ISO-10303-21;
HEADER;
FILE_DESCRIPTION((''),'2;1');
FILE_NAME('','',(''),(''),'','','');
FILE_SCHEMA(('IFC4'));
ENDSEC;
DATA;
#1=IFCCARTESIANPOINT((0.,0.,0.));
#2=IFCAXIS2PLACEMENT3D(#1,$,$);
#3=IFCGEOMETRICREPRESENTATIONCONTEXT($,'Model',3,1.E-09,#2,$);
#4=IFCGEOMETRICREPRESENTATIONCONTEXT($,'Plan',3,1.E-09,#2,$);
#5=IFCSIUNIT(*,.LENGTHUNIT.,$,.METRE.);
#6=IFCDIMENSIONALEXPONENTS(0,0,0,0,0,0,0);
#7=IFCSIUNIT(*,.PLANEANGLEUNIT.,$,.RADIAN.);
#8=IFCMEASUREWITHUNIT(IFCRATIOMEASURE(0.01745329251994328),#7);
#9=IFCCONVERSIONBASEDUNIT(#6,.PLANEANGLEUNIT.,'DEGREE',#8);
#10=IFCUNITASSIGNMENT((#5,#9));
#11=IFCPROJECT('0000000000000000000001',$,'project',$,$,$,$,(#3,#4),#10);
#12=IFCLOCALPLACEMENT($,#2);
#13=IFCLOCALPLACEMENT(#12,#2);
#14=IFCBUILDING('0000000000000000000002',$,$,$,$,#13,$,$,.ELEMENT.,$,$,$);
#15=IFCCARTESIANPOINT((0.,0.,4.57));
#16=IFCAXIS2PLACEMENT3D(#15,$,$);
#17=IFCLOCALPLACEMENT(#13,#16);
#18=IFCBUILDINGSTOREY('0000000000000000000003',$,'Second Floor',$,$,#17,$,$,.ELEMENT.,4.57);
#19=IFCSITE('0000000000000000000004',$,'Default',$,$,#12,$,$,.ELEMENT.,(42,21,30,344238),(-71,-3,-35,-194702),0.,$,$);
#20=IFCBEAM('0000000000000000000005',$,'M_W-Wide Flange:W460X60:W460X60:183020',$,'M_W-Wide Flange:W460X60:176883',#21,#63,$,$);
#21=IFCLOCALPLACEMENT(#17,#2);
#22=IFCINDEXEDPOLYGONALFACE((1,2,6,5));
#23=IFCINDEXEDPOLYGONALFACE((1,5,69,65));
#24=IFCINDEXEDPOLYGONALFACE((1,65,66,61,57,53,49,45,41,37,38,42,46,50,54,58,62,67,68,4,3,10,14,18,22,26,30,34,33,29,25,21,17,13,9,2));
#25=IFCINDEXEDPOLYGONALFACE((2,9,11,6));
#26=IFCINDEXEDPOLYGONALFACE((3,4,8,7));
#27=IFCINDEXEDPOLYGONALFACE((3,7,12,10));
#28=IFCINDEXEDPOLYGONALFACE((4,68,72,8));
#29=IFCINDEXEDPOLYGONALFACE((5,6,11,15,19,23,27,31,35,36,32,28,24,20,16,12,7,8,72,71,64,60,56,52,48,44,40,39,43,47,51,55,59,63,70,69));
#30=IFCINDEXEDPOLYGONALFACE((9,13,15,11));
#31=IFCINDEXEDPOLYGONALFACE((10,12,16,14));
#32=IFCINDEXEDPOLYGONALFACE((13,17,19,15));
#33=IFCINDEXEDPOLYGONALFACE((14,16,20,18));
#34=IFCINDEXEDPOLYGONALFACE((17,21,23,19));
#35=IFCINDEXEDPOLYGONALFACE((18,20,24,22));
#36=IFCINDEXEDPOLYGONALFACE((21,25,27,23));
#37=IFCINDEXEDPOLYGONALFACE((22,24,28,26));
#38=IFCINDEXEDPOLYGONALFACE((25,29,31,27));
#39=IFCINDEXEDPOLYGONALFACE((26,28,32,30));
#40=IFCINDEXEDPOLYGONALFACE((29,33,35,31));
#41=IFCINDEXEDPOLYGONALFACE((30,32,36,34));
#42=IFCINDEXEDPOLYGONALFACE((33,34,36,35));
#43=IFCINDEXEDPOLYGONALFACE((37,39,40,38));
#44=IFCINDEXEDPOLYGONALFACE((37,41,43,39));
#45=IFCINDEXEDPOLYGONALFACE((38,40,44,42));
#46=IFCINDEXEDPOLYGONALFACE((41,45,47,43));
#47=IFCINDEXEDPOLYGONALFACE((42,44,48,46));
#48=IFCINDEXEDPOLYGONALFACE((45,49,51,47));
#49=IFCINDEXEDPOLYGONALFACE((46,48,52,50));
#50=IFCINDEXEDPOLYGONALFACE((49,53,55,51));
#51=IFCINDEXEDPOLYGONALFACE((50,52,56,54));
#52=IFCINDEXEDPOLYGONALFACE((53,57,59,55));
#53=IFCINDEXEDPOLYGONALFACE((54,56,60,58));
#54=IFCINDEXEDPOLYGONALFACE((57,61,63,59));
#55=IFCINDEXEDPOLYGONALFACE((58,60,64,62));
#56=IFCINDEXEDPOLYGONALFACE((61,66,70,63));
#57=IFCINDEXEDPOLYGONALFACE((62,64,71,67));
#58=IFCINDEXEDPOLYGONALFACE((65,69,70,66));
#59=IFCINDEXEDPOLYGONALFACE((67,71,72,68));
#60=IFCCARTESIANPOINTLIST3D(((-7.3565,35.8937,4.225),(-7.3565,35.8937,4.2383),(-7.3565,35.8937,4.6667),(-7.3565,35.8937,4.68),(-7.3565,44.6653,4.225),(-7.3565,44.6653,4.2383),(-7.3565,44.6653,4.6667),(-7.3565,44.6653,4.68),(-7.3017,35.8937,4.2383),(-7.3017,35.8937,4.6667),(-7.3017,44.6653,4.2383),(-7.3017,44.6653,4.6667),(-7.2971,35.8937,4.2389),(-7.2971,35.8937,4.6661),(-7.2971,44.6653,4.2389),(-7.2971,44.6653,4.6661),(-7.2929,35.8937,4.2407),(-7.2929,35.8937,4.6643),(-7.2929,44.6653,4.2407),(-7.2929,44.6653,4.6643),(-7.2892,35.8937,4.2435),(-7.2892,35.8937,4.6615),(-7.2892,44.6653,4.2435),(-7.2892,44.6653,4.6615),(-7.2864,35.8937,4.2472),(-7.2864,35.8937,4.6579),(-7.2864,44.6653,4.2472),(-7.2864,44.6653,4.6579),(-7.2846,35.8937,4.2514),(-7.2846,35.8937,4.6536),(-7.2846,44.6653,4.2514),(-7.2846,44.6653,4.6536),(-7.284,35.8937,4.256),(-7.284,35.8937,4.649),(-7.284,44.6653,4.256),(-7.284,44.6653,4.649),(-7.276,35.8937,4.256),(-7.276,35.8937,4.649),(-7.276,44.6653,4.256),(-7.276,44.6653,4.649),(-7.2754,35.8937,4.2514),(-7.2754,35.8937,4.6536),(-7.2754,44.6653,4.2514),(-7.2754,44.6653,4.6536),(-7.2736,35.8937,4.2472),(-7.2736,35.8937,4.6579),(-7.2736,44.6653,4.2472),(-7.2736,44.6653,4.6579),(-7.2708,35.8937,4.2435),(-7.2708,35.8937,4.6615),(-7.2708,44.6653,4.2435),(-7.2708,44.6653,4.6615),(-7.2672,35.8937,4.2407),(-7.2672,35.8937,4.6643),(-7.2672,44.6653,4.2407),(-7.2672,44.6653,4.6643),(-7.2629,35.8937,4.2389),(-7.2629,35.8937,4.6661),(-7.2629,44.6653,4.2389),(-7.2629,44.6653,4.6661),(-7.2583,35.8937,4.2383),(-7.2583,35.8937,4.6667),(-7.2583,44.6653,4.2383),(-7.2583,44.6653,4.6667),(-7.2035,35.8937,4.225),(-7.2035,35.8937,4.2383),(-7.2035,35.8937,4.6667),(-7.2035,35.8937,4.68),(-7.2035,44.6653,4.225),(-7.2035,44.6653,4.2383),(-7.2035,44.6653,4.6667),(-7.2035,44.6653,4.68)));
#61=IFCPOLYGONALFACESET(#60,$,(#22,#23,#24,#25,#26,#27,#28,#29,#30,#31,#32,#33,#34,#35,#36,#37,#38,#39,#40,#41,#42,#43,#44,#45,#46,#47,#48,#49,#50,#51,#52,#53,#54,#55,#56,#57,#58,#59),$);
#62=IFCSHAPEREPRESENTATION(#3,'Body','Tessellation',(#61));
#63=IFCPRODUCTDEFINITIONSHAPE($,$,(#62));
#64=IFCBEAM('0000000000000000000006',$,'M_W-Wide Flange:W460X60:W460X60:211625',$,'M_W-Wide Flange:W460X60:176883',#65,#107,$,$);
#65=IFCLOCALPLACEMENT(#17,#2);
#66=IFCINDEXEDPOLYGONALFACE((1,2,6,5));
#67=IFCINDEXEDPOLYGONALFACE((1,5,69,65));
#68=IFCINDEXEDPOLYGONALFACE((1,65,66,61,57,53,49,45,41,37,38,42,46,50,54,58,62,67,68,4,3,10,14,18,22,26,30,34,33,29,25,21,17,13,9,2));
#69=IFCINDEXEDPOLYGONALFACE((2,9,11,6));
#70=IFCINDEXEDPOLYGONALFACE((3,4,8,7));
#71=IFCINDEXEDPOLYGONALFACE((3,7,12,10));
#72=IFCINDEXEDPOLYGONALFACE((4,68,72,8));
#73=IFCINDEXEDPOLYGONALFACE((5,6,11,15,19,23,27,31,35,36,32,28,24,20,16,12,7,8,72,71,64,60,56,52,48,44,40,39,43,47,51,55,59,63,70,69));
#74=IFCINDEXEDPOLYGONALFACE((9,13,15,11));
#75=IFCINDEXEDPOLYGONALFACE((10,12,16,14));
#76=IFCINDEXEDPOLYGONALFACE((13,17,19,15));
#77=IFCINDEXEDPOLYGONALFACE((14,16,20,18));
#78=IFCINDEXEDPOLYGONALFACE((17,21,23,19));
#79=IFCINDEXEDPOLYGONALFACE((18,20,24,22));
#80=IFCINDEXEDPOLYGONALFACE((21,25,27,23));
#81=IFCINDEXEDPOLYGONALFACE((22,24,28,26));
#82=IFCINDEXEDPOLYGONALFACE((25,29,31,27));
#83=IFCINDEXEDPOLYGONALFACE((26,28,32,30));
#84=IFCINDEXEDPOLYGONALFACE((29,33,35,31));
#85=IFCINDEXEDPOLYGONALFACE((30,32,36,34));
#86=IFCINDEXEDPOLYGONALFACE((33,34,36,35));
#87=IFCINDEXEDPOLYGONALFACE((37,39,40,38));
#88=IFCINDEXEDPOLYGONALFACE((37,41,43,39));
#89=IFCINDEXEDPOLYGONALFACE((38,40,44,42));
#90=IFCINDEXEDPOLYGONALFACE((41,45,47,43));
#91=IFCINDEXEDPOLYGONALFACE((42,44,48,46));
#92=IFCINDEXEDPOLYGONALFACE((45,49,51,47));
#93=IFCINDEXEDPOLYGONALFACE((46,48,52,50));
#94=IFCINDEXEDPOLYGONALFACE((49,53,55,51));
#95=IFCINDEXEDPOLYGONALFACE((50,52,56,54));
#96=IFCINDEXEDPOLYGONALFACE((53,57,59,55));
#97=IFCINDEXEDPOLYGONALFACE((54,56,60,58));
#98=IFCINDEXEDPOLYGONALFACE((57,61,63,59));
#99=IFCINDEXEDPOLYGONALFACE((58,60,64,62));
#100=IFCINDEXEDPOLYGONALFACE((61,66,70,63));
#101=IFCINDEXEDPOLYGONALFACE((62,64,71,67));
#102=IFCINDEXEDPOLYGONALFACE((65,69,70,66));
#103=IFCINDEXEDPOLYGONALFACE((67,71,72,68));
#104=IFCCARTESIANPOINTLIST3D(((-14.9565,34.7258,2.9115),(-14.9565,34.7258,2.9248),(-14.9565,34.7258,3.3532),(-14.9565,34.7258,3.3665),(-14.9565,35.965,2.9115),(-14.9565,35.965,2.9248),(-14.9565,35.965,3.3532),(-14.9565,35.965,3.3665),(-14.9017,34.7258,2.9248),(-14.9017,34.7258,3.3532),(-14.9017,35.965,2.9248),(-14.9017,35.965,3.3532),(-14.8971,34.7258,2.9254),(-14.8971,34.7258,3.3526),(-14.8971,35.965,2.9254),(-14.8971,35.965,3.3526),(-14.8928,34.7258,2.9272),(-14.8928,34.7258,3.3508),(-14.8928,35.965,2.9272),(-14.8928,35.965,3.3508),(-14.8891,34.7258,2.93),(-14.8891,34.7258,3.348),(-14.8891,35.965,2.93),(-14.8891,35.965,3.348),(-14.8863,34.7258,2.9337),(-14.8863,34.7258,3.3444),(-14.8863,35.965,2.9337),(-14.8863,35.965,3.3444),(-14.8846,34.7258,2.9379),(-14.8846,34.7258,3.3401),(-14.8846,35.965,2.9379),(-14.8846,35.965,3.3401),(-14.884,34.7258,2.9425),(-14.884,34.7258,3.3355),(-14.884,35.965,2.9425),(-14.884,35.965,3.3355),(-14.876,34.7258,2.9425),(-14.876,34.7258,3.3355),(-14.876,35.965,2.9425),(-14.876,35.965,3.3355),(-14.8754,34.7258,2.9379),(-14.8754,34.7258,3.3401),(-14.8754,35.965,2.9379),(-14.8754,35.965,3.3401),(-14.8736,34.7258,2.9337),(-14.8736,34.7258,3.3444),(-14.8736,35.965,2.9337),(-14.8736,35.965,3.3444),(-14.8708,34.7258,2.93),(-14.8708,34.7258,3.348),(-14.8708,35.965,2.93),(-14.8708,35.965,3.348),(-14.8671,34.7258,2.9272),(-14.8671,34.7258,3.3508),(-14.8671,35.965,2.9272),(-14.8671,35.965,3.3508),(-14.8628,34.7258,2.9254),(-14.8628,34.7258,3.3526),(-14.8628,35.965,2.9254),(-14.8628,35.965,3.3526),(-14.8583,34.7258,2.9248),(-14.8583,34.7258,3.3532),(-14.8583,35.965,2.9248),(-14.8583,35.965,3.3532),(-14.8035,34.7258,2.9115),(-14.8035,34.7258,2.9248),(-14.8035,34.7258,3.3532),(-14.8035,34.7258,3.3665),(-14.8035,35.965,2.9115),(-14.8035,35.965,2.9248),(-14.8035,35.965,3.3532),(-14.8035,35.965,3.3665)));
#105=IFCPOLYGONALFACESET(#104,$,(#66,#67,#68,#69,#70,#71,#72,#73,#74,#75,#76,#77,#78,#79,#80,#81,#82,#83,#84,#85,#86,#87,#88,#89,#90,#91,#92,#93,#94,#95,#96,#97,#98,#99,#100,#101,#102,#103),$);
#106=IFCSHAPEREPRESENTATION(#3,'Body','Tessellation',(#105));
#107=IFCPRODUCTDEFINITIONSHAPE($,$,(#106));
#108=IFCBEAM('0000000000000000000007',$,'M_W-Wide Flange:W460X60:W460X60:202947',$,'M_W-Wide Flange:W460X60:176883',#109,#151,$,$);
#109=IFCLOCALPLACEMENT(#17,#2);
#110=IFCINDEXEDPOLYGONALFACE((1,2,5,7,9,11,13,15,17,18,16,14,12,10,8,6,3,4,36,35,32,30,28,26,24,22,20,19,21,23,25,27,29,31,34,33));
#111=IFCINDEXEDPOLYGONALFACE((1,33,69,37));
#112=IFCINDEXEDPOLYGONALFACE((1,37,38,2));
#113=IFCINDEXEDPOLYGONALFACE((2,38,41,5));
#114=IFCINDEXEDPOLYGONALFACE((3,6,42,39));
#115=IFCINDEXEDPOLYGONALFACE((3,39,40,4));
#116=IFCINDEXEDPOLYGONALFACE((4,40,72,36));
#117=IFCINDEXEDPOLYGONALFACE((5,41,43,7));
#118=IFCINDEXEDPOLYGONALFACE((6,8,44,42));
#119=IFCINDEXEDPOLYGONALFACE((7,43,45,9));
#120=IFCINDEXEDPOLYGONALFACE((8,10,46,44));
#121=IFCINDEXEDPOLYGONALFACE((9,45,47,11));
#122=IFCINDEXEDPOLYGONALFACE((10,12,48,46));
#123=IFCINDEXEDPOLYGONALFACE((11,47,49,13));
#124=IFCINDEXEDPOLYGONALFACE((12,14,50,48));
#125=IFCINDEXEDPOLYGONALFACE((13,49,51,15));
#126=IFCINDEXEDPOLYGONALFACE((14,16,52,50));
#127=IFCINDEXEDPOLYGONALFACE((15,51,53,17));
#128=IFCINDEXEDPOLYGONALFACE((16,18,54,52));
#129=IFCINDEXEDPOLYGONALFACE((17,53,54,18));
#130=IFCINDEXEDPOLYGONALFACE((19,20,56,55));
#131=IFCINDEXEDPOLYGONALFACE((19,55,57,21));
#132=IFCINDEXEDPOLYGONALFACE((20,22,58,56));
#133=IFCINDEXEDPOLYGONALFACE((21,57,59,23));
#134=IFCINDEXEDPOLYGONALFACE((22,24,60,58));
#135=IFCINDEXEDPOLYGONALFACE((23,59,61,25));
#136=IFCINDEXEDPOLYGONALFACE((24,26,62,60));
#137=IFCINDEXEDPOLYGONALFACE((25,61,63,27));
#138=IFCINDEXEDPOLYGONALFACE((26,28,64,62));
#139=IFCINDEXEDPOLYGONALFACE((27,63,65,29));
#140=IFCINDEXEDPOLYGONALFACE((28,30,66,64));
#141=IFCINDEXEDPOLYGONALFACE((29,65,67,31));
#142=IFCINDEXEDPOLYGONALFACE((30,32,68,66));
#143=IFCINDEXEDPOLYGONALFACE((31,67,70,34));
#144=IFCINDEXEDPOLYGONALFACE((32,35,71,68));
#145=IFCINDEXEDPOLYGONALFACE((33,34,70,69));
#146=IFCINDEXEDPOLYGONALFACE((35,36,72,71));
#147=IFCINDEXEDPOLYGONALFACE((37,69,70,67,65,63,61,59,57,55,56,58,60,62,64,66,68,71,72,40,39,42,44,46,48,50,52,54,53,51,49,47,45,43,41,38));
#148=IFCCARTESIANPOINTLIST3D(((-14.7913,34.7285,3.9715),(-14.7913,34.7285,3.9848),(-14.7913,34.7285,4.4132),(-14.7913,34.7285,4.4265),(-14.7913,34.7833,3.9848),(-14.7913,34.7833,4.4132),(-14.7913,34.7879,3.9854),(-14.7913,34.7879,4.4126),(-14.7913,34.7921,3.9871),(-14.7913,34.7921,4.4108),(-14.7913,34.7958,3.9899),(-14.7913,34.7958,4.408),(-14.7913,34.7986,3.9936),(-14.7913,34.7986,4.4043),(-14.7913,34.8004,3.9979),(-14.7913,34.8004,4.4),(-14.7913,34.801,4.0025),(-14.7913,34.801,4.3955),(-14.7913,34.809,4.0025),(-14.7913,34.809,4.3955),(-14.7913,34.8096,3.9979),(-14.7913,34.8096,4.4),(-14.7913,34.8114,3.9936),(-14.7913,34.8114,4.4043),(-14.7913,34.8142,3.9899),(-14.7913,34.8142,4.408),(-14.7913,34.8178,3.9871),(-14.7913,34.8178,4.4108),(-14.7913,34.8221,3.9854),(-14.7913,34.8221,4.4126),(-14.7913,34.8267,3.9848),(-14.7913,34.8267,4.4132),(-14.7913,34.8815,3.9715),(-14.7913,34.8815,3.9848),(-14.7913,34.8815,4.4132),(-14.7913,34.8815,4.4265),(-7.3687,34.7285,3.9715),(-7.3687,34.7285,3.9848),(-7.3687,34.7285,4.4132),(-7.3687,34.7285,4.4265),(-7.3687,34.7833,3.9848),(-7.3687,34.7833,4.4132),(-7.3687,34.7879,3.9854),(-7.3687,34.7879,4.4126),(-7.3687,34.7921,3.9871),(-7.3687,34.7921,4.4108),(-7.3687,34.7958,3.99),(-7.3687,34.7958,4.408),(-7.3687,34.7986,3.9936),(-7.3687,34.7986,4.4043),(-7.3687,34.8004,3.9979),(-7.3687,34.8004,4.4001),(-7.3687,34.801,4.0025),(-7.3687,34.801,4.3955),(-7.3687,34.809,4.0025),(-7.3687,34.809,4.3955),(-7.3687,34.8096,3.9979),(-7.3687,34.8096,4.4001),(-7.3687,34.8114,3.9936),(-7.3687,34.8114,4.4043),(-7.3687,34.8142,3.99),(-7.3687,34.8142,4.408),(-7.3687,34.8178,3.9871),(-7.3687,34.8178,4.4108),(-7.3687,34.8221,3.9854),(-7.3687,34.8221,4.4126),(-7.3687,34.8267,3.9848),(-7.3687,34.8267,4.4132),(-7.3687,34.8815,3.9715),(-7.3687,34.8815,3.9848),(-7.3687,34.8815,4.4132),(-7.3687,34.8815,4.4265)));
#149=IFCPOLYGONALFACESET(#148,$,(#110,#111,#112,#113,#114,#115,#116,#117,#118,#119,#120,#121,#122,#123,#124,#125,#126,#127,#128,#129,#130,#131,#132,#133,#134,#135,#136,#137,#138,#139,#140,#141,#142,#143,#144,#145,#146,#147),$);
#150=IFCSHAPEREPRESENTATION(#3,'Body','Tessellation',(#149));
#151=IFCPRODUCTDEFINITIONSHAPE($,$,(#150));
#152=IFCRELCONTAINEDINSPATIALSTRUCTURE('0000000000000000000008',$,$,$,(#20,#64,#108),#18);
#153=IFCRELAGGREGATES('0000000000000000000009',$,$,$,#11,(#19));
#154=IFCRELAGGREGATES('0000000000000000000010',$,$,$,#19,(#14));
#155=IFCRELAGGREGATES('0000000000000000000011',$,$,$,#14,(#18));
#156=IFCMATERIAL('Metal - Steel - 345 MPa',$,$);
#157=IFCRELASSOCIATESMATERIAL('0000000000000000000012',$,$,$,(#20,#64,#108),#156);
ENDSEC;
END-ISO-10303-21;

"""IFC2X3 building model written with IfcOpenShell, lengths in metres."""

from ifc_helpers import new_model, entity, si_unit, converted_unit, frame, frame_2d, origin, place, context, project, spatial, polyline, circle_curve, parameter, trimmed, segment, composite_curve, outline, extrude, material, element, save


model = new_model("IFC2X3")

# Units and contexts
model_context = context("Model", 3, precision=1e-09, world=origin())
plan_context = context("Plan", 3, precision=1e-09, world=origin())
ifc_project = project(units=[si_unit("LENGTHUNIT", "METRE"), converted_unit("PLANEANGLEUNIT", "DEGREE", entity("IfcRatioMeasure", 0.01745329251994328), si_unit("PLANEANGLEUNIT", "RADIAN"), dimensions=[0, 0, 0, 0, 0, 0, 0])], contexts=[model_context, plan_context])

# Site, building, storey
site_placement = place(None, origin())
site = spatial("IfcSite", under=ifc_project, at=site_placement, Name="Default", CompositionType="ELEMENT", RefLatitude=(42, 21, 30, 344238), RefLongitude=(-71, -3, -35, -194702), RefElevation=0.0)
building_placement = place(site_placement, origin())
building = spatial("IfcBuilding", under=site, at=building_placement, CompositionType="ELEMENT")
storey_placement = place(building_placement, frame((0.0, 0.0, 4.57)))
storey = spatial("IfcBuildingStorey", under=building, at=storey_placement, Name="Second Floor", CompositionType="ELEMENT", Elevation=4.57)

# Shared definitions
ifc_material = material(Name="Metal - Steel - 345 MPa")

# Beams
beam_1_placement = place(storey_placement, frame((-7.28, 35.0119, 4.68)))
element("IfcBeam", 1, at=beam_1_placement, inside=storey, material=ifc_material, Name="M_W-Wide Flange:W460X60:W460X60:183020", ObjectType="M_W-Wide Flange:W460X60:176883", context=model_context, shape_type="SweptSolid", body=[
    extrude(outline(composite_curve([segment(polyline([(-0.0765, -0.2142), (-0.0765, -0.2275)]), True, "CONTINUOUS"), segment(polyline([(-0.0765, -0.2275), (0.0765, -0.2275)]), True, "CONTINUOUS"), segment(polyline([(0.0765, -0.2275), (0.0765, -0.2142)]), True, "CONTINUOUS"), segment(polyline([(0.0765, -0.2142), (0.0217, -0.2142)]), True, "CONTINUOUS"), segment(trimmed(circle_curve(frame_2d((0.0217, -0.1965), x_axis=(1.0, 0.0)), 0.0177), [parameter(180.0)], [parameter(270.0)], True, "PARAMETER"), False, "CONTINUOUS"), segment(polyline([(0.004, -0.1965), (0.004, 0.1965)]), True, "CONTINUOUS"), segment(trimmed(circle_curve(frame_2d((0.0217, 0.1965), x_axis=(1.0, 0.0)), 0.0177), [parameter(90.0)], [parameter(180.0)], True, "PARAMETER"), False, "CONTINUOUS"), segment(polyline([(0.0217, 0.2142), (0.0765, 0.2142)]), True, "CONTINUOUS"), segment(polyline([(0.0765, 0.2142), (0.0765, 0.2275)]), True, "CONTINUOUS"), segment(polyline([(0.0765, 0.2275), (-0.0765, 0.2275)]), True, "CONTINUOUS"), segment(polyline([(-0.0765, 0.2275), (-0.0765, 0.2142)]), True, "CONTINUOUS"), segment(polyline([(-0.0765, 0.2142), (-0.0217, 0.2142)]), True, "CONTINUOUS"), segment(trimmed(circle_curve(frame_2d((-0.0217, 0.1965), x_axis=(1.0, 0.0)), 0.0177), [parameter(360.0)], [parameter(90.0)], True, "PARAMETER"), False, "CONTINUOUS"), segment(polyline([(-0.004, 0.1965), (-0.004, -0.1965)]), True, "CONTINUOUS"), segment(trimmed(circle_curve(frame_2d((-0.0217, -0.1965), x_axis=(1.0, 0.0)), 0.0177), [parameter(270.0)], [parameter(0.0)], True, "PARAMETER"), False, "CONTINUOUS"), segment(polyline([(-0.0217, -0.2142), (-0.0765, -0.2142)]), True, "CONTINUOUS")], self_intersect=False)), frame((0.0, 0.8818, -0.2275), z_axis=(0.0, -1.0, 0.0), x_axis=(1.0, 0.0, 0.0)), (0.0, 0.0, -1.0), 8.7716),
])
beam_2_placement = place(storey_placement, frame((-14.88, 35.0646, 3.3665), z_axis=(0.0, 0.0, 1.0), x_axis=(-1.0, 0.0, 0.0)))
element("IfcBeam", 2, at=beam_2_placement, inside=storey, material=ifc_material, Name="M_W-Wide Flange:W460X60:W460X60:211625", ObjectType="M_W-Wide Flange:W460X60:176883", context=model_context, shape_type="SweptSolid", body=[
    extrude(outline(composite_curve([segment(polyline([(0.2142, -0.0765), (0.2275, -0.0765)]), True, "CONTINUOUS"), segment(polyline([(0.2275, -0.0765), (0.2275, 0.0765)]), True, "CONTINUOUS"), segment(polyline([(0.2275, 0.0765), (0.2142, 0.0765)]), True, "CONTINUOUS"), segment(polyline([(0.2142, 0.0765), (0.2142, 0.0217)]), True, "CONTINUOUS"), segment(trimmed(circle_curve(frame_2d((0.1965, 0.0217), x_axis=(0.0, 1.0)), 0.0177), [parameter(180.0)], [parameter(270.0)], True, "PARAMETER"), False, "CONTINUOUS"), segment(polyline([(0.1965, 0.004), (-0.1965, 0.004)]), True, "CONTINUOUS"), segment(trimmed(circle_curve(frame_2d((-0.1965, 0.0217), x_axis=(0.0, 1.0)), 0.0177), [parameter(90.0)], [parameter(180.0)], True, "PARAMETER"), False, "CONTINUOUS"), segment(polyline([(-0.2142, 0.0217), (-0.2142, 0.0765)]), True, "CONTINUOUS"), segment(polyline([(-0.2142, 0.0765), (-0.2275, 0.0765)]), True, "CONTINUOUS"), segment(polyline([(-0.2275, 0.0765), (-0.2275, -0.0765)]), True, "CONTINUOUS"), segment(polyline([(-0.2275, -0.0765), (-0.2142, -0.0765)]), True, "CONTINUOUS"), segment(polyline([(-0.2142, -0.0765), (-0.2142, -0.0217)]), True, "CONTINUOUS"), segment(trimmed(circle_curve(frame_2d((-0.1965, -0.0217), x_axis=(0.0, 1.0)), 0.0177), [parameter(360.0)], [parameter(90.0)], True, "PARAMETER"), False, "CONTINUOUS"), segment(polyline([(-0.1965, -0.004), (0.1965, -0.004)]), True, "CONTINUOUS"), segment(trimmed(circle_curve(frame_2d((0.1965, -0.0217), x_axis=(0.0, 1.0)), 0.0177), [parameter(270.0)], [parameter(0.0)], True, "PARAMETER"), False, "CONTINUOUS"), segment(polyline([(0.2142, -0.0217), (0.2142, -0.0765)]), True, "CONTINUOUS")], self_intersect=False)), frame((0.0, 0.3388, -0.2275), z_axis=(0.0, -1.0, 0.0), x_axis=(0.0, 0.0, -1.0)), (0.0, 0.0, 1.0), 1.2392),
])
beam_3_placement = place(storey_placement, frame((-7.6802, 34.805, 4.4265), z_axis=(-0.000002, 0.0, 1.0), x_axis=(0.0, 1.0, 0.0)))
element("IfcBeam", 3, at=beam_3_placement, inside=storey, material=ifc_material, Name="M_W-Wide Flange:W460X60:W460X60:202947", ObjectType="M_W-Wide Flange:W460X60:176883", context=model_context, shape_type="SweptSolid", body=[
    extrude(outline(composite_curve([segment(polyline([(0.2142, -0.0765), (0.2275, -0.0765)]), True, "CONTINUOUS"), segment(polyline([(0.2275, -0.0765), (0.2275, 0.0765)]), True, "CONTINUOUS"), segment(polyline([(0.2275, 0.0765), (0.2142, 0.0765)]), True, "CONTINUOUS"), segment(polyline([(0.2142, 0.0765), (0.2142, 0.0217)]), True, "CONTINUOUS"), segment(trimmed(circle_curve(frame_2d((0.1965, 0.0217), x_axis=(0.0, 1.0)), 0.0177), [parameter(180.0)], [parameter(270.0)], True, "PARAMETER"), False, "CONTINUOUS"), segment(polyline([(0.1965, 0.004), (-0.1965, 0.004)]), True, "CONTINUOUS"), segment(trimmed(circle_curve(frame_2d((-0.1965, 0.0217), x_axis=(0.0, 1.0)), 0.0177), [parameter(90.0)], [parameter(180.0)], True, "PARAMETER"), False, "CONTINUOUS"), segment(polyline([(-0.2142, 0.0217), (-0.2142, 0.0765)]), True, "CONTINUOUS"), segment(polyline([(-0.2142, 0.0765), (-0.2275, 0.0765)]), True, "CONTINUOUS"), segment(polyline([(-0.2275, 0.0765), (-0.2275, -0.0765)]), True, "CONTINUOUS"), segment(polyline([(-0.2275, -0.0765), (-0.2142, -0.0765)]), True, "CONTINUOUS"), segment(polyline([(-0.2142, -0.0765), (-0.2142, -0.0217)]), True, "CONTINUOUS"), segment(trimmed(circle_curve(frame_2d((-0.1965, -0.0217), x_axis=(0.0, 1.0)), 0.0177), [parameter(360.0)], [parameter(90.0)], True, "PARAMETER"), False, "CONTINUOUS"), segment(polyline([(-0.1965, -0.004), (0.1965, -0.004)]), True, "CONTINUOUS"), segment(trimmed(circle_curve(frame_2d((0.1965, -0.0217), x_axis=(0.0, 1.0)), 0.0177), [parameter(270.0)], [parameter(0.0)], True, "PARAMETER"), False, "CONTINUOUS"), segment(polyline([(0.2142, -0.0217), (0.2142, -0.0765)]), True, "CONTINUOUS")], self_intersect=False)), frame((0.0, 7.111, -0.2275), z_axis=(0.0, -1.0, 0.0), x_axis=(0.0, 0.0, -1.0)), (0.0, 0.0, 1.0), 7.4226),
])

save(model, "model.ifc")
